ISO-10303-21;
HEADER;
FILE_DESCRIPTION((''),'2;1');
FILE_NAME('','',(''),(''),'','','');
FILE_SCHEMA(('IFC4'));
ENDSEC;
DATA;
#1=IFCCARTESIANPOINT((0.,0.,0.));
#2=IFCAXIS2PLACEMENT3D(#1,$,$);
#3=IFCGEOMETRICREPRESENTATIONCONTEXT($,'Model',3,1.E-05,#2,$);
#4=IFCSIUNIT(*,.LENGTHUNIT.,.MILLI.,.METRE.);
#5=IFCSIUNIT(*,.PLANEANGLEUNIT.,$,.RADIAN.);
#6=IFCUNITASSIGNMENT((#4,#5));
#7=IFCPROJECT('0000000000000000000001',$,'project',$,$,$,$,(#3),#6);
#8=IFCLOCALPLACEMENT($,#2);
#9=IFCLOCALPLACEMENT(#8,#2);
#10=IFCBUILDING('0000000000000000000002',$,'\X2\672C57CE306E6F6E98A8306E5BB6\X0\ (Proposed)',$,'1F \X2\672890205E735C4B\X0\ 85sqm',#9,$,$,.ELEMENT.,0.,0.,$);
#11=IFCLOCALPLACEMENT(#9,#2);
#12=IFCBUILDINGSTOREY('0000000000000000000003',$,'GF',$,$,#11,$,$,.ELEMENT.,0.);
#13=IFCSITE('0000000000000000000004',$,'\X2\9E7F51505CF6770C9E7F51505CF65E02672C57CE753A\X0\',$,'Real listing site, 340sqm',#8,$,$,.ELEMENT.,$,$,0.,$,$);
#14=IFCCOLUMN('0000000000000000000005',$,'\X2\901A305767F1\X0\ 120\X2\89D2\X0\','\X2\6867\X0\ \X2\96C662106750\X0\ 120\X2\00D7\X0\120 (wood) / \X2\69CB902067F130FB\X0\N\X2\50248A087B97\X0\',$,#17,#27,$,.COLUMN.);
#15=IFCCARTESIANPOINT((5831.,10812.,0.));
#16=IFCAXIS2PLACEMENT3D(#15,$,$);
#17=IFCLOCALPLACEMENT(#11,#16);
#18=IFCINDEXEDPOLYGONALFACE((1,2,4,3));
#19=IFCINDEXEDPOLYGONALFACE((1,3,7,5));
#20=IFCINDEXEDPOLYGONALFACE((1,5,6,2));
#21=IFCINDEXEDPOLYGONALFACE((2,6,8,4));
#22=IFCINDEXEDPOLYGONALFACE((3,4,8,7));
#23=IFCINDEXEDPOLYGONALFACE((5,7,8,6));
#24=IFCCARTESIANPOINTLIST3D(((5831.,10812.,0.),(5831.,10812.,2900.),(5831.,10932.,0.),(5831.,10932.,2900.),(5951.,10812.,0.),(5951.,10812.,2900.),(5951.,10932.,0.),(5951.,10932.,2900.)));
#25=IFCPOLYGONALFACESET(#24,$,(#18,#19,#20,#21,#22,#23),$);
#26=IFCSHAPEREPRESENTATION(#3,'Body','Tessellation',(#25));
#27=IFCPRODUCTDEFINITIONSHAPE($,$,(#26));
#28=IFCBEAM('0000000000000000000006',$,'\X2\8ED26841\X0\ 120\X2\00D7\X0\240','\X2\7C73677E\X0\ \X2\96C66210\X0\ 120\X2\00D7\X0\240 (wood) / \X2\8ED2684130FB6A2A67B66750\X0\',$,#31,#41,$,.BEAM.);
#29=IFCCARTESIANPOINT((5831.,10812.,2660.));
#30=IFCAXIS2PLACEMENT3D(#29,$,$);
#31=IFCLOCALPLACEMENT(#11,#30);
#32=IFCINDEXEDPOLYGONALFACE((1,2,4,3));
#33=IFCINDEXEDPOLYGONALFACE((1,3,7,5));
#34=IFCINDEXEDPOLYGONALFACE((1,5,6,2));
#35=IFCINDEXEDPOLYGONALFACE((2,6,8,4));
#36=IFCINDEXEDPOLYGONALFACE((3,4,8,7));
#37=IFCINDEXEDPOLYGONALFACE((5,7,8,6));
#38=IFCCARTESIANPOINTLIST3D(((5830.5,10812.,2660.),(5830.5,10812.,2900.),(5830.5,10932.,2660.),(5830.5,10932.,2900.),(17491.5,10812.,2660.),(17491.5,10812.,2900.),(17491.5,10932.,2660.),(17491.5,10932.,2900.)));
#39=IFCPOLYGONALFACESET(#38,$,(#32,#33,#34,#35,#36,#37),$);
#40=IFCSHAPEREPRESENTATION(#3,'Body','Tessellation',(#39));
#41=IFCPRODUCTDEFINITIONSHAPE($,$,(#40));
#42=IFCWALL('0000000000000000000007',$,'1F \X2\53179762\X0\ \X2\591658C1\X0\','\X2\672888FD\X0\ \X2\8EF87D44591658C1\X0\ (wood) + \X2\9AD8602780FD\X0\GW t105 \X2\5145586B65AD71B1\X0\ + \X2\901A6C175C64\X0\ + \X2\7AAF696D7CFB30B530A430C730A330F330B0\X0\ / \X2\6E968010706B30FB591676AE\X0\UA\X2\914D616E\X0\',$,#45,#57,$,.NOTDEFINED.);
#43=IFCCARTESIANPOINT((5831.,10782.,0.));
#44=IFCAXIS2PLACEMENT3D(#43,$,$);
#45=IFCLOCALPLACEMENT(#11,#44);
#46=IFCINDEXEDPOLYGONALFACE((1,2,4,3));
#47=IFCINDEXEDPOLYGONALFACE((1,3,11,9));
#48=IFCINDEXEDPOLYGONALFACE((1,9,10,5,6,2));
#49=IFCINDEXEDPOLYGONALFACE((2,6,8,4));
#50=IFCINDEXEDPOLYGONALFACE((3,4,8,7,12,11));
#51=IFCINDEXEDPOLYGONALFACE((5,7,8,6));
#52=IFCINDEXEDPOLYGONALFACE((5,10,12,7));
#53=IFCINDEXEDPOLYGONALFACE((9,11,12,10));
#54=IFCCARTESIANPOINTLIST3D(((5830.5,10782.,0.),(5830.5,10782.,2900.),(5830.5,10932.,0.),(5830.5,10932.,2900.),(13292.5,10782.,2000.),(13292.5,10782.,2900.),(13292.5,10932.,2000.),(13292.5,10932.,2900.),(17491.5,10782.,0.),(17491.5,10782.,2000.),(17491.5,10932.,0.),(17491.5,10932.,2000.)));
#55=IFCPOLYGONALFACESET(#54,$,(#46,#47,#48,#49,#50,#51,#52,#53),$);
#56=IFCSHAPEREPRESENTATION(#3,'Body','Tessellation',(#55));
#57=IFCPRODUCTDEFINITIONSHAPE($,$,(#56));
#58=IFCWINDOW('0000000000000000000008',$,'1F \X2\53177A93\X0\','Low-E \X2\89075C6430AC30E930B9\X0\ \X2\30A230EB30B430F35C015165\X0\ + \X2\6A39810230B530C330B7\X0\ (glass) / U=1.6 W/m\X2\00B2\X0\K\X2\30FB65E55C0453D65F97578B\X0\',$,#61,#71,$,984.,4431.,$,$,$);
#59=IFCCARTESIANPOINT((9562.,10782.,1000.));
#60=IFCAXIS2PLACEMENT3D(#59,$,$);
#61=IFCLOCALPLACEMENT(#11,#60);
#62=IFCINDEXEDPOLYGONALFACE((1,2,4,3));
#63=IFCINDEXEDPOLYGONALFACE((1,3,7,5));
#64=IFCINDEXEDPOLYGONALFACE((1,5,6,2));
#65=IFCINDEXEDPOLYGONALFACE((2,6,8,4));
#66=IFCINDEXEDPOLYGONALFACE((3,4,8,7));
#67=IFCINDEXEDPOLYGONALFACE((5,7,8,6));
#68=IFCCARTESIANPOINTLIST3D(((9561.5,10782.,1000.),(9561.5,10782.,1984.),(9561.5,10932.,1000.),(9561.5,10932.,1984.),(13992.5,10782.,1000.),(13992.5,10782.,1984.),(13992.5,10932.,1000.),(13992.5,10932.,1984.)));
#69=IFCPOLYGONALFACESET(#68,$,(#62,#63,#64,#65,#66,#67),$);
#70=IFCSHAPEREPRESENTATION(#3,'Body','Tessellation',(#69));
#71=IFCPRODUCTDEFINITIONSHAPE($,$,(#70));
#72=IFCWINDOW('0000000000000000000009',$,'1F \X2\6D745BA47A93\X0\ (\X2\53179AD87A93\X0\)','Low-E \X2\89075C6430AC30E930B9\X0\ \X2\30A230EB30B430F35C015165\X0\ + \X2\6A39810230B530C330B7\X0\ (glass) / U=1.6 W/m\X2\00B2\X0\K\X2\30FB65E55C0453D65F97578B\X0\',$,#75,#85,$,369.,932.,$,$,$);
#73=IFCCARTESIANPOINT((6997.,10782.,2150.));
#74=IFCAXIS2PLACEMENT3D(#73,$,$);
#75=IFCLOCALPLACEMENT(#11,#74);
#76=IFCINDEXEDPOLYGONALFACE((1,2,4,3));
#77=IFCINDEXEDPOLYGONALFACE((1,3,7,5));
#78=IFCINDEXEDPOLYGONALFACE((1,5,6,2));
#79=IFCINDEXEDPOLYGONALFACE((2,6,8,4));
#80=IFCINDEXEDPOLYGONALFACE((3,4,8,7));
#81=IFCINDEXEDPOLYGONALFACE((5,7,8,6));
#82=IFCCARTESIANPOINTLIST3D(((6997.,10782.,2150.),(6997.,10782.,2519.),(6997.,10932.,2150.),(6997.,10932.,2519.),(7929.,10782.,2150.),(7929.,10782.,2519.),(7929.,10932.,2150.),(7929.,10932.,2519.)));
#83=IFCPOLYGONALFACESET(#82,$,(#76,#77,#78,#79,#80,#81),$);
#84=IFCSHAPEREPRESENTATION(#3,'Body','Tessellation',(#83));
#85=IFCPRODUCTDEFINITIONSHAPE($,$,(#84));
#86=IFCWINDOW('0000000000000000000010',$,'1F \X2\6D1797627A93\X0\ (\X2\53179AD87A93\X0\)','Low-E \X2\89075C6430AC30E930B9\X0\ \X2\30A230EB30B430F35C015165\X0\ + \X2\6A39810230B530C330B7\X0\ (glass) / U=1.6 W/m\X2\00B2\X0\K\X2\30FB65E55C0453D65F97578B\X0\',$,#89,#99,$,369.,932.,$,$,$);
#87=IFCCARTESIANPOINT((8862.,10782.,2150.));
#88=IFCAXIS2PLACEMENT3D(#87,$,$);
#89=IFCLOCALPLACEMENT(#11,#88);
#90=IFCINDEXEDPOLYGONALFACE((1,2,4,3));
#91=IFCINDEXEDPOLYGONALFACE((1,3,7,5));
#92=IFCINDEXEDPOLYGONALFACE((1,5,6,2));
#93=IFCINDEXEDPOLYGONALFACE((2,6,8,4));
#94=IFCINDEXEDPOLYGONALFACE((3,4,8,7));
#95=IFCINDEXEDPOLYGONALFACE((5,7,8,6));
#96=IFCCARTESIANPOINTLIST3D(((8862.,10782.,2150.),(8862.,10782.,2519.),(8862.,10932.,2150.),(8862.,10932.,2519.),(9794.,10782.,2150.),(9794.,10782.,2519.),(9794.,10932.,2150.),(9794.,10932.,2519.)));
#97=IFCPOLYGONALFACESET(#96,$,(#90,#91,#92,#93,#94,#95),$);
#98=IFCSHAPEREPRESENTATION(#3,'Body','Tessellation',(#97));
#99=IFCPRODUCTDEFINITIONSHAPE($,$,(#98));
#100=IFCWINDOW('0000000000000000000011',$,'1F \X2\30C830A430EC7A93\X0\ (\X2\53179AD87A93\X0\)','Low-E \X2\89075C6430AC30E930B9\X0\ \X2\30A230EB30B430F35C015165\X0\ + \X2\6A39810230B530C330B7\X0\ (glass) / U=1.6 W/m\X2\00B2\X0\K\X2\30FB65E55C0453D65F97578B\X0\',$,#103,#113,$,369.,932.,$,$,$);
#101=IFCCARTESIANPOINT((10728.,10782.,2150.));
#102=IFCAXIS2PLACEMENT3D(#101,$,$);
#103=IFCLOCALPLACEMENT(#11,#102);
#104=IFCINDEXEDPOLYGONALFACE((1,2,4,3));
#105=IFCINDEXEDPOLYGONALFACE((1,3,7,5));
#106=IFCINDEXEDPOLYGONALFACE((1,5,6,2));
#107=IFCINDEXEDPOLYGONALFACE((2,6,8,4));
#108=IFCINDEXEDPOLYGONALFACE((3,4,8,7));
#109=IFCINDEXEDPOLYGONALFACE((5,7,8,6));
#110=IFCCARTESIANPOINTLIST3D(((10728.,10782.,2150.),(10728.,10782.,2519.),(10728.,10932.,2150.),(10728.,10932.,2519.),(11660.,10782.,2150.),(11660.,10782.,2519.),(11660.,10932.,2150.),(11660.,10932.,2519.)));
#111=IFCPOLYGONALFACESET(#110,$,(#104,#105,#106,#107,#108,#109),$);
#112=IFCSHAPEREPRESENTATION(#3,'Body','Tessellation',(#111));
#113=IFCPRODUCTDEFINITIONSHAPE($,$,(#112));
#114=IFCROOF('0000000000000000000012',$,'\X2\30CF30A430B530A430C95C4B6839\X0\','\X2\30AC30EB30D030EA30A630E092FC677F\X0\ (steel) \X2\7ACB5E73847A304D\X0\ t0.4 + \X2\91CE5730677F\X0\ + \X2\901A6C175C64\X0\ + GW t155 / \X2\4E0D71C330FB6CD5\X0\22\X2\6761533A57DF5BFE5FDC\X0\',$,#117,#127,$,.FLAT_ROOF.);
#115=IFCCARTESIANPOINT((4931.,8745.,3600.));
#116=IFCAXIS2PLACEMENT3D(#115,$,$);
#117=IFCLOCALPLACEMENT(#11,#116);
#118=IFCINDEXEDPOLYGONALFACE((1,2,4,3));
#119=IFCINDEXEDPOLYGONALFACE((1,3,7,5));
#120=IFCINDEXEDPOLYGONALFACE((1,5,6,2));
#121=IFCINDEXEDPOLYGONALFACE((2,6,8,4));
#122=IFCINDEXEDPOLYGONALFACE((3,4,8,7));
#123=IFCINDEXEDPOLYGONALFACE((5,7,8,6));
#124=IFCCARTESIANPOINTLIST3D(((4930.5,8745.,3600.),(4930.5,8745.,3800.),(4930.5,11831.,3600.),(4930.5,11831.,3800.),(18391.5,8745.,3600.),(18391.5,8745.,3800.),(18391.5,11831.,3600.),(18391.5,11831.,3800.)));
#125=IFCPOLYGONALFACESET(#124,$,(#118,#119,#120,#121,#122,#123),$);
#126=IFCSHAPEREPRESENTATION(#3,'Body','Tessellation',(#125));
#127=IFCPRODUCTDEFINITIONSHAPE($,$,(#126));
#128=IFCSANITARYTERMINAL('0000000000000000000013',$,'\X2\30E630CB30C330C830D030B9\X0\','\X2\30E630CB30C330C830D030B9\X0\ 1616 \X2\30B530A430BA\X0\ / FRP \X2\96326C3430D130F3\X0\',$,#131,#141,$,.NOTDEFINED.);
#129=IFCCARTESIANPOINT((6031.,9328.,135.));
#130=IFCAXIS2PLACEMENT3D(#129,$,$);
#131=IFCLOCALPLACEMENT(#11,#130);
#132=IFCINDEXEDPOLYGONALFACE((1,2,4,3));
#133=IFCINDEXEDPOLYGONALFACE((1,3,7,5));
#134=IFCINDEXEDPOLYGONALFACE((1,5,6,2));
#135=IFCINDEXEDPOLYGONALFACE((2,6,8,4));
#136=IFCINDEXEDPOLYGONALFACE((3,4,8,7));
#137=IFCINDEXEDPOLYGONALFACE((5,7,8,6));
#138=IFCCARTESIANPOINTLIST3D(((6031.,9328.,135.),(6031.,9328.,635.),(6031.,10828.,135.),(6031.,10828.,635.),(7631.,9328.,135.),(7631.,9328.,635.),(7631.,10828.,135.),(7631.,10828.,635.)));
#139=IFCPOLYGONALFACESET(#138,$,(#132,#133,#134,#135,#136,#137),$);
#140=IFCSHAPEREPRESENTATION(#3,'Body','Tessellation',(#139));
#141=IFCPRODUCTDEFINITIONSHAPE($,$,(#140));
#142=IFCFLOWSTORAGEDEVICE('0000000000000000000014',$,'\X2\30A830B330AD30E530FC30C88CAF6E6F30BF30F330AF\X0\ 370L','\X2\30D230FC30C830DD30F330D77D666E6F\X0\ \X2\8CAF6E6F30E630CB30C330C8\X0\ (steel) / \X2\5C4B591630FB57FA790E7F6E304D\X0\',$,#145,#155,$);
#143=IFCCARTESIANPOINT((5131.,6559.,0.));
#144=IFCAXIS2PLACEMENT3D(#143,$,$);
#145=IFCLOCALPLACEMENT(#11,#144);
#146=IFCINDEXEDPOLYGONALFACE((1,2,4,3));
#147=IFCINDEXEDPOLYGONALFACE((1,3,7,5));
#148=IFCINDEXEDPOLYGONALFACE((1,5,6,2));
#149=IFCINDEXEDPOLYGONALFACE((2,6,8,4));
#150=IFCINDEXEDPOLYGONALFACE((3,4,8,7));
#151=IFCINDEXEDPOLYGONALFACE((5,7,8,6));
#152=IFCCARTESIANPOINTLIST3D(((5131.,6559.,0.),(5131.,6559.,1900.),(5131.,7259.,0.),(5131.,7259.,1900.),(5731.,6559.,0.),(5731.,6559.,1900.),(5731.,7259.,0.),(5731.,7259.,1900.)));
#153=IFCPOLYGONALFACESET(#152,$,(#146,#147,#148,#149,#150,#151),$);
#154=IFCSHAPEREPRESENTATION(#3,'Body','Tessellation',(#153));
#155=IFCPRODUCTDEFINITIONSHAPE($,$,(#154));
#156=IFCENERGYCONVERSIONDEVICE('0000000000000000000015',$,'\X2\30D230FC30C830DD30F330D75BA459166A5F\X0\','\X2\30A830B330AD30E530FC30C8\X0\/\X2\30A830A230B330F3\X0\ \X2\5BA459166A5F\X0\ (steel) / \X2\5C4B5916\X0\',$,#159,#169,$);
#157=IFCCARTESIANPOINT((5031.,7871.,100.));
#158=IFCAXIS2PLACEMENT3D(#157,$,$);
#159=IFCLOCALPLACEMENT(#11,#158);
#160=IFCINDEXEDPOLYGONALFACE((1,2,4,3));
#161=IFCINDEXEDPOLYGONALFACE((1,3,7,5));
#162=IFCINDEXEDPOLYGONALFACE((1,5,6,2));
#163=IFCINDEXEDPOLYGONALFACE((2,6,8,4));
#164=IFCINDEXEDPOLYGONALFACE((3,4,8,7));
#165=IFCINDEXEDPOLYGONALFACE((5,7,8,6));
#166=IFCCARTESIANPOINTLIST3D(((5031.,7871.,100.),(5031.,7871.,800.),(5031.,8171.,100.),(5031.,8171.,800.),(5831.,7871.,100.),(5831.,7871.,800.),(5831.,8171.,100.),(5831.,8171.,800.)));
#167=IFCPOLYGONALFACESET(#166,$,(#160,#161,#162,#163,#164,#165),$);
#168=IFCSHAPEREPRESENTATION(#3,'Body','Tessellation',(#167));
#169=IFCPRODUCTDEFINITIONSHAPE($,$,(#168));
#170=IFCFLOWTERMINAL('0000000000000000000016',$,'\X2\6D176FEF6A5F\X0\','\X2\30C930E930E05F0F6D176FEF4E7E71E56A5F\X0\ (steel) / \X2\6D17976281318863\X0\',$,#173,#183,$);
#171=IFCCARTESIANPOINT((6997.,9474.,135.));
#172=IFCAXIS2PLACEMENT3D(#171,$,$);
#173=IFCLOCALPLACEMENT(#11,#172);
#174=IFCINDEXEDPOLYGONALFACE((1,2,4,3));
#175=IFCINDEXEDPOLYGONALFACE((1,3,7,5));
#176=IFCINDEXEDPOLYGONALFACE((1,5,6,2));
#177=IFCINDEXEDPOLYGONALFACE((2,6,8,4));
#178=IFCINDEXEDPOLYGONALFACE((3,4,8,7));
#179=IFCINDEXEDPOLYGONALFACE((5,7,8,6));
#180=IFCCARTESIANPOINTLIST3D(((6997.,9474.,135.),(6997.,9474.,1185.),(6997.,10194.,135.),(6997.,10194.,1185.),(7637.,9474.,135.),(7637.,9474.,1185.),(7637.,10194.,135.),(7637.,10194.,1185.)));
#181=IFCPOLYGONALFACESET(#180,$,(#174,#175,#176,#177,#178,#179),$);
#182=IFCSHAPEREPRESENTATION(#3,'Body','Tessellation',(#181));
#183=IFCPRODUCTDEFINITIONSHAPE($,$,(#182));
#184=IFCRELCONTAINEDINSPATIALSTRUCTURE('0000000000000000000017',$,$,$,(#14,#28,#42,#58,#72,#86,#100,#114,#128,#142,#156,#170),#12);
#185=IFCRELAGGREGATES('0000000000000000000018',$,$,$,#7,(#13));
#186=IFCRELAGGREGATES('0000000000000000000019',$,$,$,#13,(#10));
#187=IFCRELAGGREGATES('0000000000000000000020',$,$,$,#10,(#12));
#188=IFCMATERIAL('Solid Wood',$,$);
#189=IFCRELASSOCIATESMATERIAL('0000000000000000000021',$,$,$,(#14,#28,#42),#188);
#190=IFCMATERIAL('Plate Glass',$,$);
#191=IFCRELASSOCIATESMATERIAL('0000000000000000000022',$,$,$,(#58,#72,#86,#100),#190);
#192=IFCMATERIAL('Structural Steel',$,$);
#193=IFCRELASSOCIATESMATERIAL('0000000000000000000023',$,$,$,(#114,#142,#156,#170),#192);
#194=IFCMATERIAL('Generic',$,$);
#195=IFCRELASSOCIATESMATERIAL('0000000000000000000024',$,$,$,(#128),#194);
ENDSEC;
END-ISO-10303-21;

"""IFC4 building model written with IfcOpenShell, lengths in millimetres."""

from ifc_helpers import new_model, si_unit, frame, frame_2d, origin, place, context, project, spatial, rectangle, extrude, material, element, fill, save


model = new_model("IFC4")

# Units and contexts
model_context = context("Model", 3, precision=1e-05, world=origin())
ifc_project = project(units=[si_unit("LENGTHUNIT", "METRE", prefix="MILLI"), si_unit("PLANEANGLEUNIT", "RADIAN")], contexts=[model_context])

# Site, building, storey
site_placement = place(None, origin())
site = spatial("IfcSite", under=ifc_project, at=site_placement, Name="鹿児島県鹿児島市本城町", ObjectType="Real listing site, 340sqm", CompositionType="ELEMENT", RefElevation=0.0)
building_placement = place(site_placement, origin())
building = spatial("IfcBuilding", under=site, at=building_placement, Name="本城の潮風の家 (Proposed)", ObjectType="1F 木造平屋 85sqm", CompositionType="ELEMENT", ElevationOfRefHeight=0.0, ElevationOfTerrain=0.0)
storey_placement = place(building_placement, origin())
storey = spatial("IfcBuildingStorey", under=building, at=storey_placement, Name="GF", CompositionType="ELEMENT", Elevation=0.0)

# Column
ifc_material_1 = material(Name="Solid Wood")
column_1_placement = place(storey_placement, frame((5831.0, 10812.0, 0.0)))
element("IfcColumn", 1, at=column_1_placement, inside=storey, material=ifc_material_1, Name="通し柱 120角", Description="桧 集成材 120×120 (wood) / 構造柱・N値計算", PredefinedType="COLUMN", context=model_context, shape_type="SweptSolid", body=[
    extrude(rectangle(XDim=120.0, YDim=120.0, at=frame_2d((60.0, 60.0))), frame((5831.0, 10812.0, 0.0)), (0.0, 0.0, 1.0), 2900.0),
])

# Beam
beam_1_placement = place(storey_placement, frame((5831.0, 10812.0, 2660.0)))
element("IfcBeam", 2, at=beam_1_placement, inside=storey, material=ifc_material_1, Name="軒桁 120×240", Description="米松 集成 120×240 (wood) / 軒桁・横架材", PredefinedType="BEAM", context=model_context, shape_type="SweptSolid", body=[
    extrude(rectangle(XDim=11661.0, YDim=120.0, at=frame_2d((5830.0, 60.0))), frame((5831.0, 10812.0, 2660.0)), (0.0, 0.0, 1.0), 240.0),
])

# Wall, openings, windows
wall_1_placement = place(storey_placement, frame((5831.0, 10782.0, 0.0)))
wall_1 = element("IfcWall", 3, at=wall_1_placement, inside=storey, material=ifc_material_1, Name="1F 北面 外壁", Description="木製 軸組外壁 (wood) + 高性能GW t105 充填断熱 + 通気層 + 窯業系サイディング / 準耐火・外皮UA配慮", PredefinedType="NOTDEFINED", context=model_context, shape_type="SweptSolid", body=[
    extrude(rectangle(XDim=11661.0, YDim=150.0, at=frame_2d((5830.0, 75.0))), frame((5831.0, 10782.0, 0.0)), (0.0, 0.0, 1.0), 2900.0),
])
opening_1_placement = place(storey_placement, frame((9562.0, 10782.0, 1000.0)))
opening_1 = element("IfcOpeningElement", 4, at=opening_1_placement, cuts=wall_1, PredefinedType="NOTDEFINED", context=model_context, shape_type="SweptSolid", body=[
    extrude(rectangle(XDim=4431.0, YDim=150.0, at=frame_2d((2215.0, 75.0))), frame((9562.0, 10782.0, 1000.0)), (0.0, 0.0, 1.0), 984.0),
])
opening_2_placement = place(storey_placement, frame((6997.0, 10782.0, 2150.0)))
opening_2 = element("IfcOpeningElement", 5, at=opening_2_placement, cuts=wall_1, PredefinedType="NOTDEFINED", context=model_context, shape_type="SweptSolid", body=[
    extrude(rectangle(XDim=932.0, YDim=150.0, at=frame_2d((466.0, 75.0))), frame((6997.0, 10782.0, 2150.0)), (0.0, 0.0, 1.0), 369.0),
])
opening_3_placement = place(storey_placement, frame((8862.0, 10782.0, 2150.0)))
opening_3 = element("IfcOpeningElement", 6, at=opening_3_placement, cuts=wall_1, PredefinedType="NOTDEFINED", context=model_context, shape_type="SweptSolid", body=[
    extrude(rectangle(XDim=932.0, YDim=150.0, at=frame_2d((466.0, 75.0))), frame((8862.0, 10782.0, 2150.0)), (0.0, 0.0, 1.0), 369.0),
])
opening_4_placement = place(storey_placement, frame((10728.0, 10782.0, 2150.0)))
opening_4 = element("IfcOpeningElement", 7, at=opening_4_placement, cuts=wall_1, PredefinedType="NOTDEFINED", context=model_context, shape_type="SweptSolid", body=[
    extrude(rectangle(XDim=932.0, YDim=150.0, at=frame_2d((466.0, 75.0))), frame((10728.0, 10782.0, 2150.0)), (0.0, 0.0, 1.0), 369.0),
])
ifc_material_2 = material(Name="Plate Glass")
window_1_placement = place(storey_placement, frame((9562.0, 10782.0, 1000.0)))
window_1 = element("IfcWindow", 8, at=window_1_placement, inside=storey, material=ifc_material_2, Name="1F 北窓", Description="Low-E 複層ガラス アルゴン封入 + 樹脂サッシ (glass) / U=1.6 W/m²K・日射取得型", OverallHeight=984.0, OverallWidth=4431.0, context=model_context, shape_type="SweptSolid", body=[
    extrude(rectangle(XDim=4431.0, YDim=150.0, at=frame_2d((2215.0, 75.0))), frame((9562.0, 10782.0, 1000.0)), (0.0, 0.0, 1.0), 984.0),
])
fill(opening_1, window_1)
window_2_placement = place(storey_placement, frame((6997.0, 10782.0, 2150.0)))
window_2 = element("IfcWindow", 9, at=window_2_placement, inside=storey, material=ifc_material_2, Name="1F 浴室窓 (北高窓)", Description="Low-E 複層ガラス アルゴン封入 + 樹脂サッシ (glass) / U=1.6 W/m²K・日射取得型", OverallHeight=369.0, OverallWidth=932.0, context=model_context, shape_type="SweptSolid", body=[
    extrude(rectangle(XDim=932.0, YDim=150.0, at=frame_2d((466.0, 75.0))), frame((6997.0, 10782.0, 2150.0)), (0.0, 0.0, 1.0), 369.0),
])
fill(opening_2, window_2)
window_3_placement = place(storey_placement, frame((8862.0, 10782.0, 2150.0)))
window_3 = element("IfcWindow", 10, at=window_3_placement, inside=storey, material=ifc_material_2, Name="1F 洗面窓 (北高窓)", Description="Low-E 複層ガラス アルゴン封入 + 樹脂サッシ (glass) / U=1.6 W/m²K・日射取得型", OverallHeight=369.0, OverallWidth=932.0, context=model_context, shape_type="SweptSolid", body=[
    extrude(rectangle(XDim=932.0, YDim=150.0, at=frame_2d((466.0, 75.0))), frame((8862.0, 10782.0, 2150.0)), (0.0, 0.0, 1.0), 369.0),
])
fill(opening_3, window_3)
window_4_placement = place(storey_placement, frame((10728.0, 10782.0, 2150.0)))
window_4 = element("IfcWindow", 11, at=window_4_placement, inside=storey, material=ifc_material_2, Name="1F トイレ窓 (北高窓)", Description="Low-E 複層ガラス アルゴン封入 + 樹脂サッシ (glass) / U=1.6 W/m²K・日射取得型", OverallHeight=369.0, OverallWidth=932.0, context=model_context, shape_type="SweptSolid", body=[
    extrude(rectangle(XDim=932.0, YDim=150.0, at=frame_2d((466.0, 75.0))), frame((10728.0, 10782.0, 2150.0)), (0.0, 0.0, 1.0), 369.0),
])
fill(opening_4, window_4)

# Roof
ifc_material_3 = material(Name="Structural Steel")
roof_placement = place(storey_placement, frame((4931.0, 8745.0, 3600.0)))
element("IfcRoof", 12, at=roof_placement, inside=storey, material=ifc_material_3, Name="ハイサイド屋根", Description="ガルバリウム鋼板 (steel) 立平葺き t0.4 + 野地板 + 通気層 + GW t155 / 不燃・法22条区域対応", PredefinedType="FLAT_ROOF", context=model_context, shape_type="SweptSolid", body=[
    extrude(rectangle(XDim=13461.0, YDim=3086.0, at=frame_2d((6730.0, 1543.0))), frame((4931.0, 8745.0, 3600.0)), (0.0, 0.0, 1.0), 200.0),
])

# Sanitary terminal
ifc_material_4 = material(Name="Generic")
sanitary_terminal_placement = place(storey_placement, frame((6031.0, 9328.0, 135.0)))
element("IfcSanitaryTerminal", 13, at=sanitary_terminal_placement, inside=storey, material=ifc_material_4, Name="ユニットバス", Description="ユニットバス 1616 サイズ / FRP 防水パン", PredefinedType="NOTDEFINED", context=model_context, shape_type="SweptSolid", body=[
    extrude(rectangle(XDim=1600.0, YDim=1500.0, at=frame_2d((800.0, 750.0))), frame((6031.0, 9328.0, 135.0)), (0.0, 0.0, 1.0), 500.0),
])

# Flow storage device
flow_storage_device_placement = place(storey_placement, frame((5131.0, 6559.0, 0.0)))
element("IfcFlowStorageDevice", 14, at=flow_storage_device_placement, inside=storey, material=ifc_material_3, Name="エコキュート貯湯タンク 370L", Description="ヒートポンプ給湯 貯湯ユニット (steel) / 屋外・基礎置き", context=model_context, shape_type="SweptSolid", body=[
    extrude(rectangle(XDim=600.0, YDim=700.0, at=frame_2d((300.0, 350.0))), frame((5131.0, 6559.0, 0.0)), (0.0, 0.0, 1.0), 1900.0),
])

# Energy conversion device
energy_conversion_device_placement = place(storey_placement, frame((5031.0, 7871.0, 100.0)))
element("IfcEnergyConversionDevice", 15, at=energy_conversion_device_placement, inside=storey, material=ifc_material_3, Name="ヒートポンプ室外機", Description="エコキュート/エアコン 室外機 (steel) / 屋外", context=model_context, shape_type="SweptSolid", body=[
    extrude(rectangle(XDim=800.0, YDim=300.0, at=frame_2d((400.0, 150.0))), frame((5031.0, 7871.0, 100.0)), (0.0, 0.0, 1.0), 700.0),
])

# Flow terminal
flow_terminal_placement = place(storey_placement, frame((6997.0, 9474.0, 135.0)))
element("IfcFlowTerminal", 16, at=flow_terminal_placement, inside=storey, material=ifc_material_3, Name="洗濯機", Description="ドラム式洗濯乾燥機 (steel) / 洗面脱衣", context=model_context, shape_type="SweptSolid", body=[
    extrude(rectangle(XDim=640.0, YDim=720.0, at=frame_2d((320.0, 360.0))), frame((6997.0, 9474.0, 135.0)), (0.0, 0.0, 1.0), 1050.0),
])

save(model, "model.ifc")
